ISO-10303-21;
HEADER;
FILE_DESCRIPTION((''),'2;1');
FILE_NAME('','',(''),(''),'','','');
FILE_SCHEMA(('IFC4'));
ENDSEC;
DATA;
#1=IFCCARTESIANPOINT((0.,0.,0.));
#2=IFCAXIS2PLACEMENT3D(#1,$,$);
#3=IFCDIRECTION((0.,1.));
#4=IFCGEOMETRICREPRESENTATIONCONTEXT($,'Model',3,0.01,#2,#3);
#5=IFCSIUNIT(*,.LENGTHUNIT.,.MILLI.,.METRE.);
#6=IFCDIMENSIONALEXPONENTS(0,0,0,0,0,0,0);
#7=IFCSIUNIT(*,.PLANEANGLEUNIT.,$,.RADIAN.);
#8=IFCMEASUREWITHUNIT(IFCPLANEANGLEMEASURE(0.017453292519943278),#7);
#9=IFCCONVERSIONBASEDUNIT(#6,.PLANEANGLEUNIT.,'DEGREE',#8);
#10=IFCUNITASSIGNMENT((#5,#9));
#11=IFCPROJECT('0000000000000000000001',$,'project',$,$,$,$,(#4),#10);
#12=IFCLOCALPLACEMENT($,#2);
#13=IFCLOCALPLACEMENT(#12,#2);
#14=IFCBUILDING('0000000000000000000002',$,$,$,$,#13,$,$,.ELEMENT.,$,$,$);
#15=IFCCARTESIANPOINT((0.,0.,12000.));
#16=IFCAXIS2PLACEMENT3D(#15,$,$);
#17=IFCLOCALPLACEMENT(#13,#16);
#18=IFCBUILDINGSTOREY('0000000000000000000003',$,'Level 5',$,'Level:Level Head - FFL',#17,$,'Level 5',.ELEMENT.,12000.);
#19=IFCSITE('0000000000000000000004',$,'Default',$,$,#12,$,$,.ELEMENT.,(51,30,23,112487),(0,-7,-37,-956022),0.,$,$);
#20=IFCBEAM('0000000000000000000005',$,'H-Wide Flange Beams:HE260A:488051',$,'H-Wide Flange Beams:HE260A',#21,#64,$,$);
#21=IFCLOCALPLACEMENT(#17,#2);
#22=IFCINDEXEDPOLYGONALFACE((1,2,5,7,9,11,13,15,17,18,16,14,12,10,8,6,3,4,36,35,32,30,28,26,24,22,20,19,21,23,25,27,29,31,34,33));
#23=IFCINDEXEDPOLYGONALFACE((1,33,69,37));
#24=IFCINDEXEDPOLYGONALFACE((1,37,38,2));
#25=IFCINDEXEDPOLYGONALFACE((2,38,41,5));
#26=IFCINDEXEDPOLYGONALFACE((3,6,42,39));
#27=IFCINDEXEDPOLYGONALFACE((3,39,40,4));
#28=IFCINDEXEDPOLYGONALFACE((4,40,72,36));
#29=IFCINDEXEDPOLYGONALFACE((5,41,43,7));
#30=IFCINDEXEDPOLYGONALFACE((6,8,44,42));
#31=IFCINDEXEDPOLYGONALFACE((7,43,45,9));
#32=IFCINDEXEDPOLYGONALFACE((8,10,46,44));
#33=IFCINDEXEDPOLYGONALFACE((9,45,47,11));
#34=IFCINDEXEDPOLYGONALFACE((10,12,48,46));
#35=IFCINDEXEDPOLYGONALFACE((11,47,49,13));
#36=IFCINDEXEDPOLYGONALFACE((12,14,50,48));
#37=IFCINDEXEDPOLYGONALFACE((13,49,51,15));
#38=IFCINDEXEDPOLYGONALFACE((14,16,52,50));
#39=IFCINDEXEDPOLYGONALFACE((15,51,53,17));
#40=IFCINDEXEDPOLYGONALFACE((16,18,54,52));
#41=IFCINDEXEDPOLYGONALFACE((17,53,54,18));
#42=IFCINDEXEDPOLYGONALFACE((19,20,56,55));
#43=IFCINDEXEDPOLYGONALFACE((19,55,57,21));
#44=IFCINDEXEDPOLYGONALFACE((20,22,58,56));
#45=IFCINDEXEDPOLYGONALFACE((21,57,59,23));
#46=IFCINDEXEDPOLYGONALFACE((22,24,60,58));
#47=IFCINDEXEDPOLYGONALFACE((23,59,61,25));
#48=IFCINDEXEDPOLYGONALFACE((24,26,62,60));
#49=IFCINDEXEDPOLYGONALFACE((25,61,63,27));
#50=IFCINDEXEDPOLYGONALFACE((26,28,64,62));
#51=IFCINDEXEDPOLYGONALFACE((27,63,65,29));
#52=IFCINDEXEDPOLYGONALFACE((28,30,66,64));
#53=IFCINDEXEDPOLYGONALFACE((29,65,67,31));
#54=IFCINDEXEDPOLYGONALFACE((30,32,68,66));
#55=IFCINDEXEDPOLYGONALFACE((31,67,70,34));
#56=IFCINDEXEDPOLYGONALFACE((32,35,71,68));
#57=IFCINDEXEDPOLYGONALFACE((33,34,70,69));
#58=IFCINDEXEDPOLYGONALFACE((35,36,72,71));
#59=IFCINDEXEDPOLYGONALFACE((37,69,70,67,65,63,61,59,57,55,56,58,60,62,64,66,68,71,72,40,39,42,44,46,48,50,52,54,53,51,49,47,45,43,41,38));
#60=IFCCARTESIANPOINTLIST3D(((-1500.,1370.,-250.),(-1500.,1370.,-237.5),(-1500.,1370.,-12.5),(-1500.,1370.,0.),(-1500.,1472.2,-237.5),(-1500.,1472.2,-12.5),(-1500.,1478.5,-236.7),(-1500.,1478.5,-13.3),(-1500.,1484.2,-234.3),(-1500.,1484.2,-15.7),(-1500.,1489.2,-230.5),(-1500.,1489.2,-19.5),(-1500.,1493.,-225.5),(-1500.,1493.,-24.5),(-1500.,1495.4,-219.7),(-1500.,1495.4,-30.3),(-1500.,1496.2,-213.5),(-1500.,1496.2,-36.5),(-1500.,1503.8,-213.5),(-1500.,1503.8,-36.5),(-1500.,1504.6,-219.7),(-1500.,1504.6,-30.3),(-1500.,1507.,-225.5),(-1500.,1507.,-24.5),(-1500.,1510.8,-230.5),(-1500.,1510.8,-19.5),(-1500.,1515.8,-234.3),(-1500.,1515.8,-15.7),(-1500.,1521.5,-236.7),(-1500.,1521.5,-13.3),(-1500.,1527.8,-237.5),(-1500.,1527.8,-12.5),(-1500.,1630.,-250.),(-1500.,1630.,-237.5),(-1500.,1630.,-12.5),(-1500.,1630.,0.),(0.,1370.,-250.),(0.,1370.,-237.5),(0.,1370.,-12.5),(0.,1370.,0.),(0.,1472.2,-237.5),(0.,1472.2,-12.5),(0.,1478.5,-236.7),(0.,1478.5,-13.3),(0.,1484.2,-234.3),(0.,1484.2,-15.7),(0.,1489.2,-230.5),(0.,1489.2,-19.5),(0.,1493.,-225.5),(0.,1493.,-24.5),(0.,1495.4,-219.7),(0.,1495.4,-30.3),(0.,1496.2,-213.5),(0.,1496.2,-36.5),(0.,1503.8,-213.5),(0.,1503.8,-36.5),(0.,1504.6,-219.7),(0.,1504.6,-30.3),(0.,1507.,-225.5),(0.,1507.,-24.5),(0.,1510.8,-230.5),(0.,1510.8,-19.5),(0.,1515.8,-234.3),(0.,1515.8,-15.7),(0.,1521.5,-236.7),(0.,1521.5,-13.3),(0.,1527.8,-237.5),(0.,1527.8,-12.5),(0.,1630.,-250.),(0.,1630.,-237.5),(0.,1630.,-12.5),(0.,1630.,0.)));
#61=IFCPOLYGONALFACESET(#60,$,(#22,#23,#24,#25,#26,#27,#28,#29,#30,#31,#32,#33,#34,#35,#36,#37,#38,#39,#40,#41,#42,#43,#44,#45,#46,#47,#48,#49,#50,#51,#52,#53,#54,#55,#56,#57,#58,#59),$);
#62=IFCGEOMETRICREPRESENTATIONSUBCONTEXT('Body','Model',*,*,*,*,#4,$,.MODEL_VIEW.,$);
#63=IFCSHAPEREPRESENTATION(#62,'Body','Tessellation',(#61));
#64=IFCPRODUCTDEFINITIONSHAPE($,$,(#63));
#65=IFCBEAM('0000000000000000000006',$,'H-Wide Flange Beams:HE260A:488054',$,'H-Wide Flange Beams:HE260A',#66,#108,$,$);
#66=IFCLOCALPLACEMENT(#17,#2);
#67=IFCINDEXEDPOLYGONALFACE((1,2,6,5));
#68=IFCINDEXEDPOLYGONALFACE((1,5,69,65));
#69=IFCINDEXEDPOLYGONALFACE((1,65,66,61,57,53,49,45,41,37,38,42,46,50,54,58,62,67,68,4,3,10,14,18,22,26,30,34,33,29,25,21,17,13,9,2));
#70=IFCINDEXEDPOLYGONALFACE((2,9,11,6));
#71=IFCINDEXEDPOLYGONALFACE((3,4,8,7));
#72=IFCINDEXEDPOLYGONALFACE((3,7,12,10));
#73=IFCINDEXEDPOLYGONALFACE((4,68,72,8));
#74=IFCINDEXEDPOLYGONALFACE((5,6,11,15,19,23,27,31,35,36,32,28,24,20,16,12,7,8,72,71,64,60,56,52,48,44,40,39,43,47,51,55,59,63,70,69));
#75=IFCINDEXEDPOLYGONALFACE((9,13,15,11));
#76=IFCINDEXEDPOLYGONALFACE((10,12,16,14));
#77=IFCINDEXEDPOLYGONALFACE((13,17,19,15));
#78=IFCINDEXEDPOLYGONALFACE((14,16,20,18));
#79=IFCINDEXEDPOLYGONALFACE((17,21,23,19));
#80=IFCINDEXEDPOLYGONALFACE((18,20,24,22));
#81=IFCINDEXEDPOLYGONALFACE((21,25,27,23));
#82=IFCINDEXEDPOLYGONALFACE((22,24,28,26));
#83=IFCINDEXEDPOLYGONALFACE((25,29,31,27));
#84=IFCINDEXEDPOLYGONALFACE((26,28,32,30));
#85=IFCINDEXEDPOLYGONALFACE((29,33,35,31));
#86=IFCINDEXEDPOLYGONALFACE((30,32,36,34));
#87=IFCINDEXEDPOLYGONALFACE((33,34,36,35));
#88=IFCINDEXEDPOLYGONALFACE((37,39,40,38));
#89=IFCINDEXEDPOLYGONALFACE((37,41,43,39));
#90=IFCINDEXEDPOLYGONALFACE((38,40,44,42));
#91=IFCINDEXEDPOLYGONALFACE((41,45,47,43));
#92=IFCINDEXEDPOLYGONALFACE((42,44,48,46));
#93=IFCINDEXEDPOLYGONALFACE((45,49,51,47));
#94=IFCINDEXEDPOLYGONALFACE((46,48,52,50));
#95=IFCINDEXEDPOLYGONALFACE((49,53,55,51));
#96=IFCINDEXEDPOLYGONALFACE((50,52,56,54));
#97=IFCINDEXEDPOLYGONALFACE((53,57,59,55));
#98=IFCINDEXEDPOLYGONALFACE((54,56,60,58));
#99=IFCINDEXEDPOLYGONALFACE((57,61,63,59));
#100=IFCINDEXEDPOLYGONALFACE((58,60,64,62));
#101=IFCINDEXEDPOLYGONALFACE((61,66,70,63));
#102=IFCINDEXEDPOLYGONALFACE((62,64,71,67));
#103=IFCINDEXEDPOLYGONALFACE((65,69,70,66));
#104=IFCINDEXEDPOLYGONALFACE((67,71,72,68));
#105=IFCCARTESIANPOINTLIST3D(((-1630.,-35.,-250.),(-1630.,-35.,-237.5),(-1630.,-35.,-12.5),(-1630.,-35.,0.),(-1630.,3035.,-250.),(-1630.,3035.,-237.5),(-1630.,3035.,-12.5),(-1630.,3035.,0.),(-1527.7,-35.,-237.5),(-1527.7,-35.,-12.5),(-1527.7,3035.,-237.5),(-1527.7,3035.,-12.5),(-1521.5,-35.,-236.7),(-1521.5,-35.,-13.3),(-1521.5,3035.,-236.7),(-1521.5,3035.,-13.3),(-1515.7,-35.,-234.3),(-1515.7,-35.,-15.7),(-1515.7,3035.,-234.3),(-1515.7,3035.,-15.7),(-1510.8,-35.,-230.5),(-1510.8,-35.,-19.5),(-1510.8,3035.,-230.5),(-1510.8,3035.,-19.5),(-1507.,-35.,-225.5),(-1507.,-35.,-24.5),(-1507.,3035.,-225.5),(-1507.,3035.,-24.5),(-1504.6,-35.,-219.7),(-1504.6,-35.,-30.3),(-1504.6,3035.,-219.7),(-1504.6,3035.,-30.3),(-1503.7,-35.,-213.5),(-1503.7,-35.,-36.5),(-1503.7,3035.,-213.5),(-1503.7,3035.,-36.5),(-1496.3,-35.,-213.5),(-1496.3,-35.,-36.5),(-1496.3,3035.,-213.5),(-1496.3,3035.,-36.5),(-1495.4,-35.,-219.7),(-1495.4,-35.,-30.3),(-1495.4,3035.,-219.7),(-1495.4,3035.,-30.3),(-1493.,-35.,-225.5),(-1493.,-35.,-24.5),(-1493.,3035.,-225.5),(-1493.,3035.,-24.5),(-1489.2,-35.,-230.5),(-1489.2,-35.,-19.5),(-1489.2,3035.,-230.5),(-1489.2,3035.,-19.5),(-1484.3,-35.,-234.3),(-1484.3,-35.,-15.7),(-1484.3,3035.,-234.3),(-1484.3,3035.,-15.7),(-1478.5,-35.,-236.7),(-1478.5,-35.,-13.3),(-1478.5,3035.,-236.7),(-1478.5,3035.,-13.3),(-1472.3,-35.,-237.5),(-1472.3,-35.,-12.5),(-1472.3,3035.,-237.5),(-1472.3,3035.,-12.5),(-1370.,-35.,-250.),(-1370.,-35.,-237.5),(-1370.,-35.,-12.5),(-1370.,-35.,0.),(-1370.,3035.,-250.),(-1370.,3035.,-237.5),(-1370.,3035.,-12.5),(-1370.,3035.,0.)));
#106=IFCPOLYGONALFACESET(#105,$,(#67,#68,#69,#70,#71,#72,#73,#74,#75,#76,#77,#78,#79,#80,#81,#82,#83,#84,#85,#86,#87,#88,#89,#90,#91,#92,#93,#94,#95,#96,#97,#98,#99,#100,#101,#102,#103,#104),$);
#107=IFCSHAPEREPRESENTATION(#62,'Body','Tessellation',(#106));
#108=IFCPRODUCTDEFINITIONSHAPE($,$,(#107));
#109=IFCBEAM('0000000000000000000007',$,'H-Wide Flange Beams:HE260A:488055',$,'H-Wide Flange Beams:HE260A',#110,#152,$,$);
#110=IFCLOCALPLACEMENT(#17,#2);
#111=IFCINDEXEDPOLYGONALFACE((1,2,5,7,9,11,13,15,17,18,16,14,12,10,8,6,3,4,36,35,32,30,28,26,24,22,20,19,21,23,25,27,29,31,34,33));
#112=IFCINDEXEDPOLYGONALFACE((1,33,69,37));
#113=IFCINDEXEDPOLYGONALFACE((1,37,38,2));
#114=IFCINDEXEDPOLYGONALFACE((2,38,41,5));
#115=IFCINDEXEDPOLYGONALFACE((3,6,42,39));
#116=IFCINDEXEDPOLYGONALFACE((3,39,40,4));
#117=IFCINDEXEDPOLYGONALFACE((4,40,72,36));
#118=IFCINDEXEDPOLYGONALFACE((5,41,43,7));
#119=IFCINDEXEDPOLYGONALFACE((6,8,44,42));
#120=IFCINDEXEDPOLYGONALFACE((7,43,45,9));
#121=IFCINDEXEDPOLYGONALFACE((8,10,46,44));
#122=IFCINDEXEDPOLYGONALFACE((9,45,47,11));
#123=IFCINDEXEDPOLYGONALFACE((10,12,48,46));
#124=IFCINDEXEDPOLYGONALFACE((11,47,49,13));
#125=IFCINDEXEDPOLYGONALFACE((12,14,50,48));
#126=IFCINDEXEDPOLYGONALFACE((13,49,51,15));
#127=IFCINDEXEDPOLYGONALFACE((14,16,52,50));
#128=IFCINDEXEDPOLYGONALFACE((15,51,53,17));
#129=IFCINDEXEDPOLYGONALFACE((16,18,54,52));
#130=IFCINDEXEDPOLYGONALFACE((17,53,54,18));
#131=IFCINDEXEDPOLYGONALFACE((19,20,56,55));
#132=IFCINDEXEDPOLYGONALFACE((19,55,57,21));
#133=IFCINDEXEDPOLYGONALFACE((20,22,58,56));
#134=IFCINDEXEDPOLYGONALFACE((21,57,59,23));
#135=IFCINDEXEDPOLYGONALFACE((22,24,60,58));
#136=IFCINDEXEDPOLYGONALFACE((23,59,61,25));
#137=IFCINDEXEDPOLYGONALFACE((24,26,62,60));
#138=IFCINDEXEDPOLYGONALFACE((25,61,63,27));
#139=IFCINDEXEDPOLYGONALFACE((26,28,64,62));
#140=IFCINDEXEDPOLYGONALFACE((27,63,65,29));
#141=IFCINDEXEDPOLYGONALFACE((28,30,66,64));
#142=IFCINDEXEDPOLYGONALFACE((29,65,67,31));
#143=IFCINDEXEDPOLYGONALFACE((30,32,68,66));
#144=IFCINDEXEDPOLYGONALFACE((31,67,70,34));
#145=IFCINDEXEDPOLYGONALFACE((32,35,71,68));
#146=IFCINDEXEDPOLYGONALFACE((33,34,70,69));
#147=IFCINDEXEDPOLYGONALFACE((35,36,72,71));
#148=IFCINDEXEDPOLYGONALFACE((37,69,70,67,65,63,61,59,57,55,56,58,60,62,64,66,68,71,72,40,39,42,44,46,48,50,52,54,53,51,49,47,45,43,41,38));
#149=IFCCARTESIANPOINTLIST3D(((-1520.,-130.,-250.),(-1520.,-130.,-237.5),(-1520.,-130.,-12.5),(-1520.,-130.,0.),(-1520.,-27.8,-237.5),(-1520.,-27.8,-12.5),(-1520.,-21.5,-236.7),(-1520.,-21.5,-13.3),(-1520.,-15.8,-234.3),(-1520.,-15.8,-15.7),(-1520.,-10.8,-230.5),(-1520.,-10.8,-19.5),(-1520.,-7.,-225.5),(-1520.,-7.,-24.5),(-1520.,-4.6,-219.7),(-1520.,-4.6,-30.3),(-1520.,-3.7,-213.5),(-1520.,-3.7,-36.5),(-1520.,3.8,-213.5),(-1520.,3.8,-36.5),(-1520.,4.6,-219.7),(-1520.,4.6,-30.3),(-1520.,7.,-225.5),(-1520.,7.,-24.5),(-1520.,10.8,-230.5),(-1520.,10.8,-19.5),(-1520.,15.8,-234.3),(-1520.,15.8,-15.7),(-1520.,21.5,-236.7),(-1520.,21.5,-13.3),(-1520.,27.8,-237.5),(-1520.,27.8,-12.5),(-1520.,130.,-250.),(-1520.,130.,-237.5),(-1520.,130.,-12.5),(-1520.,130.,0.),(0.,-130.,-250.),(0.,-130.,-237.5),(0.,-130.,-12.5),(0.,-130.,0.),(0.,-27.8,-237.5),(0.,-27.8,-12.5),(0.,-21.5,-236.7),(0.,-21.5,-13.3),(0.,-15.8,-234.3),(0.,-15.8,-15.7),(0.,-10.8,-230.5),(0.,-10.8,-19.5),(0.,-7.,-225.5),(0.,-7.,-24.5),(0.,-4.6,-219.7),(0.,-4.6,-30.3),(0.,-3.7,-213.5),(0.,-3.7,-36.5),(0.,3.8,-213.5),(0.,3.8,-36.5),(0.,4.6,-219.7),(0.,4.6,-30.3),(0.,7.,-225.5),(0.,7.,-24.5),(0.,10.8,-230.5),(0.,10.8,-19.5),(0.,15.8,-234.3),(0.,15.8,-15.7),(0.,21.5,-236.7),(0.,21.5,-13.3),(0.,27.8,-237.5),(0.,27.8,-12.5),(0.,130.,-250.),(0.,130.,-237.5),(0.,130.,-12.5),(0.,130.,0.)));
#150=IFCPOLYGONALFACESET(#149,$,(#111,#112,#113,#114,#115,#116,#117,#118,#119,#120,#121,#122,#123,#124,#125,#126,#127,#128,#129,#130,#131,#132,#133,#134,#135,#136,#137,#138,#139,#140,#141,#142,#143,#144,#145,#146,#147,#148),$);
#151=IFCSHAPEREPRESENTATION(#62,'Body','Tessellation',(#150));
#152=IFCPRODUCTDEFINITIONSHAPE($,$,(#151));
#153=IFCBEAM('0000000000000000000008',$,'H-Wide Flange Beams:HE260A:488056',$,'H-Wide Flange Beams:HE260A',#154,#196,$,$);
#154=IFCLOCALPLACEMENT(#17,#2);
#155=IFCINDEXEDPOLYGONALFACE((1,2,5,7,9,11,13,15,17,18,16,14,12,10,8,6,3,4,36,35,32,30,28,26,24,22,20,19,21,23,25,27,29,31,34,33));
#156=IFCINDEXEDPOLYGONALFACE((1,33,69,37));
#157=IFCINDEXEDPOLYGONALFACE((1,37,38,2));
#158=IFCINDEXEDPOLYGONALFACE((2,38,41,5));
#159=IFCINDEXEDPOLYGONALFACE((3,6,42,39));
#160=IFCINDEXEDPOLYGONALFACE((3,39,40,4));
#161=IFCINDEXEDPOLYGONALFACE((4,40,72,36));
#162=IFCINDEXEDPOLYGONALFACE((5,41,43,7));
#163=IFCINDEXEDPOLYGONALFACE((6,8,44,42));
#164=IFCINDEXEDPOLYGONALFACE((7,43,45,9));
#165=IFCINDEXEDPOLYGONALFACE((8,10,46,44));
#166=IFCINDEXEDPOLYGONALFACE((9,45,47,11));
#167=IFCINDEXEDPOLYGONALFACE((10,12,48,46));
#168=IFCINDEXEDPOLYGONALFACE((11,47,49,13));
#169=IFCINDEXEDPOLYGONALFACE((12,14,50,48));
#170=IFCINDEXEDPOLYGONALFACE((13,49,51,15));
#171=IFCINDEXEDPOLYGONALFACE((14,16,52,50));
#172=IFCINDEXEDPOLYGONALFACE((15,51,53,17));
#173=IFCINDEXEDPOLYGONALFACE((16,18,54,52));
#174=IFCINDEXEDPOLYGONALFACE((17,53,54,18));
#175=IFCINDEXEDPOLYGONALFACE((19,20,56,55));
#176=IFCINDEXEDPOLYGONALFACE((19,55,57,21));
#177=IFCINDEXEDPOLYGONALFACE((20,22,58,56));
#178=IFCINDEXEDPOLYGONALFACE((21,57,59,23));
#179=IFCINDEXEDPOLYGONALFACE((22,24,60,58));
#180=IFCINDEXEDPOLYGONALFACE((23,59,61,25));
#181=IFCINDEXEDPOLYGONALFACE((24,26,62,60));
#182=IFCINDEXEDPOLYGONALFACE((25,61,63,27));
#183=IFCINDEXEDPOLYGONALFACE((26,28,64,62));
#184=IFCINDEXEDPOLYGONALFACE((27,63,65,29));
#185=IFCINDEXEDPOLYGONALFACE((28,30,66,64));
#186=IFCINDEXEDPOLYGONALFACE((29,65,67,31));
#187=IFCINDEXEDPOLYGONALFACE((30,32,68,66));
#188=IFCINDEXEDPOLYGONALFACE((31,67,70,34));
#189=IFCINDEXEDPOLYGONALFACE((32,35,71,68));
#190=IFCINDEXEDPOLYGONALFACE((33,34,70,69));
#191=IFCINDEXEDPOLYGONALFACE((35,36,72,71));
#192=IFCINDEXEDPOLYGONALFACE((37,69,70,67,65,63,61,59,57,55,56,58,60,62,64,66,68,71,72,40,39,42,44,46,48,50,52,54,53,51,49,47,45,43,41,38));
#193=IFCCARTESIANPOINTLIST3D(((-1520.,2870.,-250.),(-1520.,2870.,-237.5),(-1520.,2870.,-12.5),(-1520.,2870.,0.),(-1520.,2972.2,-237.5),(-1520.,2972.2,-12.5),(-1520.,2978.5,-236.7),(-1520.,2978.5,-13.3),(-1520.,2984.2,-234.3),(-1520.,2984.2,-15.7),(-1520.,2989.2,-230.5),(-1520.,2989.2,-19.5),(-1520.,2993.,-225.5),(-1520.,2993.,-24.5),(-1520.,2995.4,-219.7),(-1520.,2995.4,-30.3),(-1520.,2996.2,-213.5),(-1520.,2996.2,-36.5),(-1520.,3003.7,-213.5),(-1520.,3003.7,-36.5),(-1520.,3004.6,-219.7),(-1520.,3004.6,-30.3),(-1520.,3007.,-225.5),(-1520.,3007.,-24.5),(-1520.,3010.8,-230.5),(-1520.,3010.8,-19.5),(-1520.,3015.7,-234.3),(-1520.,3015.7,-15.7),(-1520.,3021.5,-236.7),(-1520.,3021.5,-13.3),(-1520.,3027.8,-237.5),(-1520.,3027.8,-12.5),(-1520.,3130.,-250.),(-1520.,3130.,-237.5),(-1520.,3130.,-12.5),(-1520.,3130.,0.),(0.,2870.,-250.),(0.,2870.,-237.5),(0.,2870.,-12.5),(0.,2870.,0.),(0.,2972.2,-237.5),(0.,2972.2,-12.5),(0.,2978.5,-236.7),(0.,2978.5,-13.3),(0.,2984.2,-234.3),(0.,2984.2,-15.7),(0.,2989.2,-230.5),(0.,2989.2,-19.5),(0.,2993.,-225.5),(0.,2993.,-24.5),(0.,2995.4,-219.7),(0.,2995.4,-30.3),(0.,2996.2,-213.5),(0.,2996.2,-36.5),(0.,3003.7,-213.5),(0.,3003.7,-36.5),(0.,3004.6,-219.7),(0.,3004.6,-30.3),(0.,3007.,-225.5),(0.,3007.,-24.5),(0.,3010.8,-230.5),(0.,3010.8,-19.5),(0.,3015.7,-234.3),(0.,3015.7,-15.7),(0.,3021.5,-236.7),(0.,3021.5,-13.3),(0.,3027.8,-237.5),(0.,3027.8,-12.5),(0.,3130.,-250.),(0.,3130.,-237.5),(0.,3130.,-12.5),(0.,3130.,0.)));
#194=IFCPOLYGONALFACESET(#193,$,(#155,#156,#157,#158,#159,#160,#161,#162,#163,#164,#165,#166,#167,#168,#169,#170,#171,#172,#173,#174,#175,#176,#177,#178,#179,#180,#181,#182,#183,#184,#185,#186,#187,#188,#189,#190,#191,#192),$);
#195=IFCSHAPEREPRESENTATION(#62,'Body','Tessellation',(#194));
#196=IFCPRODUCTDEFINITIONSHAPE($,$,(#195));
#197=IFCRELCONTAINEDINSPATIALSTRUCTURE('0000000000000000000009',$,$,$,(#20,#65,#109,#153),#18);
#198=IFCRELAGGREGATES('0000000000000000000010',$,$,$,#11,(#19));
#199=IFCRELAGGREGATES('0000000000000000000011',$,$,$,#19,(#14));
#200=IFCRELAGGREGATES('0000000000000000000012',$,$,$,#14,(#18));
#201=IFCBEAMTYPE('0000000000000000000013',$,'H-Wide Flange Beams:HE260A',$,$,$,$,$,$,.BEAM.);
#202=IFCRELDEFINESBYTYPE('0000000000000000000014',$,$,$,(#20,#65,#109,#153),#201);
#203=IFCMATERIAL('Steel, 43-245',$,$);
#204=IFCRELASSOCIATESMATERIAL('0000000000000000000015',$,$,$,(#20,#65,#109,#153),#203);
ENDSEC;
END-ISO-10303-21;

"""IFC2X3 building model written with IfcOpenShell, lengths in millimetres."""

from ifc_helpers import new_model, entity, si_unit, converted_unit, direction, frame, frame_2d, origin, place, context, subcontext, project, spatial, i_section, extrude, material, type_object, element, save


model = new_model("IFC2X3")

# Units and contexts
model_context = context("Model", 3, precision=0.01, world=origin(), true_north=direction((0.0, 1.0)))
body_context = subcontext(model_context, "Body", "Model", "MODEL_VIEW")
ifc_project = project(units=[si_unit("LENGTHUNIT", "METRE", prefix="MILLI"), converted_unit("PLANEANGLEUNIT", "DEGREE", entity("IfcPlaneAngleMeasure", 0.017453292519943278), si_unit("PLANEANGLEUNIT", "RADIAN"), dimensions=[0, 0, 0, 0, 0, 0, 0])], contexts=[model_context])

# Site, building, storey
site_placement = place(None, origin())
site = spatial("IfcSite", under=ifc_project, at=site_placement, Name="Default", CompositionType="ELEMENT", RefLatitude=(51, 30, 23, 112487), RefLongitude=(0, -7, -37, -956022), RefElevation=0.0)
building_placement = place(site_placement, origin())
building = spatial("IfcBuilding", under=site, at=building_placement, CompositionType="ELEMENT")
storey_placement = place(building_placement, frame((0.0, 0.0, 12000.0)))
storey = spatial("IfcBuildingStorey", under=building, at=storey_placement, Name="Level 5", ObjectType="Level:Level Head - FFL", LongName="Level 5", CompositionType="ELEMENT", Elevation=12000.0)

# Beams
ifc_material = material(Name="Steel, 43-245")
beam_type_1 = type_object("IfcBeamType", Name="H-Wide Flange Beams:HE260A", PredefinedType="BEAM")
beam_1_placement = place(storey_placement, frame((0.0, 1500.0, 0.0), z_axis=(0.0, 0.0, 1.0), x_axis=(-1.0, 0.0, 0.0)))
element("IfcBeam", 1, at=beam_1_placement, inside=storey, type_object=beam_type_1, material=ifc_material, Name="H-Wide Flange Beams:HE260A:488051", ObjectType="H-Wide Flange Beams:HE260A", context=body_context, shape_type="SweptSolid", body=[
    extrude(i_section(OverallWidth=260.0, OverallDepth=250.0, WebThickness=7.5, FlangeThickness=12.5, FilletRadius=24.0, at=frame_2d((0.0, 0.0), x_axis=(0.0, 1.0))), frame((0.0, 0.0, -125.0), z_axis=(1.0, 0.0, 0.0), x_axis=(0.0, 0.0, -1.0)), (0.0, 0.0, 1.0), 1500.0),
])
beam_2_placement = place(storey_placement, frame((-1500.0, 0.0, 0.0), z_axis=(0.0, 0.0, 1.0), x_axis=(0.0, 1.0, 0.0)))
element("IfcBeam", 2, at=beam_2_placement, inside=storey, type_object=beam_type_1, material=ifc_material, Name="H-Wide Flange Beams:HE260A:488054", ObjectType="H-Wide Flange Beams:HE260A", context=body_context, shape_type="SweptSolid", body=[
    extrude(i_section(OverallWidth=260.0, OverallDepth=250.0, WebThickness=7.5, FlangeThickness=12.5, FilletRadius=24.0, at=frame_2d((0.0, 0.0), x_axis=(0.0, 1.0))), frame((-35.0, 0.0, -125.0), z_axis=(1.0, 0.0, 0.0), x_axis=(0.0, 0.0, -1.0)), (0.0, 0.0, 1.0), 3070.0),
])
beam_3_placement = place(storey_placement, frame((-1500.0, 0.0, 0.0)))
element("IfcBeam", 3, at=beam_3_placement, inside=storey, type_object=beam_type_1, material=ifc_material, Name="H-Wide Flange Beams:HE260A:488055", ObjectType="H-Wide Flange Beams:HE260A", context=body_context, shape_type="SweptSolid", body=[
    extrude(i_section(OverallWidth=260.0, OverallDepth=250.0, WebThickness=7.5, FlangeThickness=12.5, FilletRadius=24.0, at=frame_2d((0.0, 0.0), x_axis=(0.0, 1.0))), frame((-20.0, 0.0, -125.0), z_axis=(1.0, 0.0, 0.0), x_axis=(0.0, 0.0, -1.0)), (0.0, 0.0, 1.0), 1520.0),
])
beam_4_placement = place(storey_placement, frame((0.0, 3000.0, 0.0), z_axis=(0.0, 0.0, 1.0), x_axis=(-1.0, 0.0, 0.0)))
element("IfcBeam", 4, at=beam_4_placement, inside=storey, type_object=beam_type_1, material=ifc_material, Name="H-Wide Flange Beams:HE260A:488056", ObjectType="H-Wide Flange Beams:HE260A", context=body_context, shape_type="SweptSolid", body=[
    extrude(i_section(OverallWidth=260.0, OverallDepth=250.0, WebThickness=7.5, FlangeThickness=12.5, FilletRadius=24.0, at=frame_2d((0.0, 0.0), x_axis=(0.0, 1.0))), frame((0.0, 0.0, -125.0), z_axis=(1.0, 0.0, 0.0), x_axis=(0.0, 0.0, -1.0)), (0.0, 0.0, 1.0), 1520.0),
])

save(model, "model.ifc")
